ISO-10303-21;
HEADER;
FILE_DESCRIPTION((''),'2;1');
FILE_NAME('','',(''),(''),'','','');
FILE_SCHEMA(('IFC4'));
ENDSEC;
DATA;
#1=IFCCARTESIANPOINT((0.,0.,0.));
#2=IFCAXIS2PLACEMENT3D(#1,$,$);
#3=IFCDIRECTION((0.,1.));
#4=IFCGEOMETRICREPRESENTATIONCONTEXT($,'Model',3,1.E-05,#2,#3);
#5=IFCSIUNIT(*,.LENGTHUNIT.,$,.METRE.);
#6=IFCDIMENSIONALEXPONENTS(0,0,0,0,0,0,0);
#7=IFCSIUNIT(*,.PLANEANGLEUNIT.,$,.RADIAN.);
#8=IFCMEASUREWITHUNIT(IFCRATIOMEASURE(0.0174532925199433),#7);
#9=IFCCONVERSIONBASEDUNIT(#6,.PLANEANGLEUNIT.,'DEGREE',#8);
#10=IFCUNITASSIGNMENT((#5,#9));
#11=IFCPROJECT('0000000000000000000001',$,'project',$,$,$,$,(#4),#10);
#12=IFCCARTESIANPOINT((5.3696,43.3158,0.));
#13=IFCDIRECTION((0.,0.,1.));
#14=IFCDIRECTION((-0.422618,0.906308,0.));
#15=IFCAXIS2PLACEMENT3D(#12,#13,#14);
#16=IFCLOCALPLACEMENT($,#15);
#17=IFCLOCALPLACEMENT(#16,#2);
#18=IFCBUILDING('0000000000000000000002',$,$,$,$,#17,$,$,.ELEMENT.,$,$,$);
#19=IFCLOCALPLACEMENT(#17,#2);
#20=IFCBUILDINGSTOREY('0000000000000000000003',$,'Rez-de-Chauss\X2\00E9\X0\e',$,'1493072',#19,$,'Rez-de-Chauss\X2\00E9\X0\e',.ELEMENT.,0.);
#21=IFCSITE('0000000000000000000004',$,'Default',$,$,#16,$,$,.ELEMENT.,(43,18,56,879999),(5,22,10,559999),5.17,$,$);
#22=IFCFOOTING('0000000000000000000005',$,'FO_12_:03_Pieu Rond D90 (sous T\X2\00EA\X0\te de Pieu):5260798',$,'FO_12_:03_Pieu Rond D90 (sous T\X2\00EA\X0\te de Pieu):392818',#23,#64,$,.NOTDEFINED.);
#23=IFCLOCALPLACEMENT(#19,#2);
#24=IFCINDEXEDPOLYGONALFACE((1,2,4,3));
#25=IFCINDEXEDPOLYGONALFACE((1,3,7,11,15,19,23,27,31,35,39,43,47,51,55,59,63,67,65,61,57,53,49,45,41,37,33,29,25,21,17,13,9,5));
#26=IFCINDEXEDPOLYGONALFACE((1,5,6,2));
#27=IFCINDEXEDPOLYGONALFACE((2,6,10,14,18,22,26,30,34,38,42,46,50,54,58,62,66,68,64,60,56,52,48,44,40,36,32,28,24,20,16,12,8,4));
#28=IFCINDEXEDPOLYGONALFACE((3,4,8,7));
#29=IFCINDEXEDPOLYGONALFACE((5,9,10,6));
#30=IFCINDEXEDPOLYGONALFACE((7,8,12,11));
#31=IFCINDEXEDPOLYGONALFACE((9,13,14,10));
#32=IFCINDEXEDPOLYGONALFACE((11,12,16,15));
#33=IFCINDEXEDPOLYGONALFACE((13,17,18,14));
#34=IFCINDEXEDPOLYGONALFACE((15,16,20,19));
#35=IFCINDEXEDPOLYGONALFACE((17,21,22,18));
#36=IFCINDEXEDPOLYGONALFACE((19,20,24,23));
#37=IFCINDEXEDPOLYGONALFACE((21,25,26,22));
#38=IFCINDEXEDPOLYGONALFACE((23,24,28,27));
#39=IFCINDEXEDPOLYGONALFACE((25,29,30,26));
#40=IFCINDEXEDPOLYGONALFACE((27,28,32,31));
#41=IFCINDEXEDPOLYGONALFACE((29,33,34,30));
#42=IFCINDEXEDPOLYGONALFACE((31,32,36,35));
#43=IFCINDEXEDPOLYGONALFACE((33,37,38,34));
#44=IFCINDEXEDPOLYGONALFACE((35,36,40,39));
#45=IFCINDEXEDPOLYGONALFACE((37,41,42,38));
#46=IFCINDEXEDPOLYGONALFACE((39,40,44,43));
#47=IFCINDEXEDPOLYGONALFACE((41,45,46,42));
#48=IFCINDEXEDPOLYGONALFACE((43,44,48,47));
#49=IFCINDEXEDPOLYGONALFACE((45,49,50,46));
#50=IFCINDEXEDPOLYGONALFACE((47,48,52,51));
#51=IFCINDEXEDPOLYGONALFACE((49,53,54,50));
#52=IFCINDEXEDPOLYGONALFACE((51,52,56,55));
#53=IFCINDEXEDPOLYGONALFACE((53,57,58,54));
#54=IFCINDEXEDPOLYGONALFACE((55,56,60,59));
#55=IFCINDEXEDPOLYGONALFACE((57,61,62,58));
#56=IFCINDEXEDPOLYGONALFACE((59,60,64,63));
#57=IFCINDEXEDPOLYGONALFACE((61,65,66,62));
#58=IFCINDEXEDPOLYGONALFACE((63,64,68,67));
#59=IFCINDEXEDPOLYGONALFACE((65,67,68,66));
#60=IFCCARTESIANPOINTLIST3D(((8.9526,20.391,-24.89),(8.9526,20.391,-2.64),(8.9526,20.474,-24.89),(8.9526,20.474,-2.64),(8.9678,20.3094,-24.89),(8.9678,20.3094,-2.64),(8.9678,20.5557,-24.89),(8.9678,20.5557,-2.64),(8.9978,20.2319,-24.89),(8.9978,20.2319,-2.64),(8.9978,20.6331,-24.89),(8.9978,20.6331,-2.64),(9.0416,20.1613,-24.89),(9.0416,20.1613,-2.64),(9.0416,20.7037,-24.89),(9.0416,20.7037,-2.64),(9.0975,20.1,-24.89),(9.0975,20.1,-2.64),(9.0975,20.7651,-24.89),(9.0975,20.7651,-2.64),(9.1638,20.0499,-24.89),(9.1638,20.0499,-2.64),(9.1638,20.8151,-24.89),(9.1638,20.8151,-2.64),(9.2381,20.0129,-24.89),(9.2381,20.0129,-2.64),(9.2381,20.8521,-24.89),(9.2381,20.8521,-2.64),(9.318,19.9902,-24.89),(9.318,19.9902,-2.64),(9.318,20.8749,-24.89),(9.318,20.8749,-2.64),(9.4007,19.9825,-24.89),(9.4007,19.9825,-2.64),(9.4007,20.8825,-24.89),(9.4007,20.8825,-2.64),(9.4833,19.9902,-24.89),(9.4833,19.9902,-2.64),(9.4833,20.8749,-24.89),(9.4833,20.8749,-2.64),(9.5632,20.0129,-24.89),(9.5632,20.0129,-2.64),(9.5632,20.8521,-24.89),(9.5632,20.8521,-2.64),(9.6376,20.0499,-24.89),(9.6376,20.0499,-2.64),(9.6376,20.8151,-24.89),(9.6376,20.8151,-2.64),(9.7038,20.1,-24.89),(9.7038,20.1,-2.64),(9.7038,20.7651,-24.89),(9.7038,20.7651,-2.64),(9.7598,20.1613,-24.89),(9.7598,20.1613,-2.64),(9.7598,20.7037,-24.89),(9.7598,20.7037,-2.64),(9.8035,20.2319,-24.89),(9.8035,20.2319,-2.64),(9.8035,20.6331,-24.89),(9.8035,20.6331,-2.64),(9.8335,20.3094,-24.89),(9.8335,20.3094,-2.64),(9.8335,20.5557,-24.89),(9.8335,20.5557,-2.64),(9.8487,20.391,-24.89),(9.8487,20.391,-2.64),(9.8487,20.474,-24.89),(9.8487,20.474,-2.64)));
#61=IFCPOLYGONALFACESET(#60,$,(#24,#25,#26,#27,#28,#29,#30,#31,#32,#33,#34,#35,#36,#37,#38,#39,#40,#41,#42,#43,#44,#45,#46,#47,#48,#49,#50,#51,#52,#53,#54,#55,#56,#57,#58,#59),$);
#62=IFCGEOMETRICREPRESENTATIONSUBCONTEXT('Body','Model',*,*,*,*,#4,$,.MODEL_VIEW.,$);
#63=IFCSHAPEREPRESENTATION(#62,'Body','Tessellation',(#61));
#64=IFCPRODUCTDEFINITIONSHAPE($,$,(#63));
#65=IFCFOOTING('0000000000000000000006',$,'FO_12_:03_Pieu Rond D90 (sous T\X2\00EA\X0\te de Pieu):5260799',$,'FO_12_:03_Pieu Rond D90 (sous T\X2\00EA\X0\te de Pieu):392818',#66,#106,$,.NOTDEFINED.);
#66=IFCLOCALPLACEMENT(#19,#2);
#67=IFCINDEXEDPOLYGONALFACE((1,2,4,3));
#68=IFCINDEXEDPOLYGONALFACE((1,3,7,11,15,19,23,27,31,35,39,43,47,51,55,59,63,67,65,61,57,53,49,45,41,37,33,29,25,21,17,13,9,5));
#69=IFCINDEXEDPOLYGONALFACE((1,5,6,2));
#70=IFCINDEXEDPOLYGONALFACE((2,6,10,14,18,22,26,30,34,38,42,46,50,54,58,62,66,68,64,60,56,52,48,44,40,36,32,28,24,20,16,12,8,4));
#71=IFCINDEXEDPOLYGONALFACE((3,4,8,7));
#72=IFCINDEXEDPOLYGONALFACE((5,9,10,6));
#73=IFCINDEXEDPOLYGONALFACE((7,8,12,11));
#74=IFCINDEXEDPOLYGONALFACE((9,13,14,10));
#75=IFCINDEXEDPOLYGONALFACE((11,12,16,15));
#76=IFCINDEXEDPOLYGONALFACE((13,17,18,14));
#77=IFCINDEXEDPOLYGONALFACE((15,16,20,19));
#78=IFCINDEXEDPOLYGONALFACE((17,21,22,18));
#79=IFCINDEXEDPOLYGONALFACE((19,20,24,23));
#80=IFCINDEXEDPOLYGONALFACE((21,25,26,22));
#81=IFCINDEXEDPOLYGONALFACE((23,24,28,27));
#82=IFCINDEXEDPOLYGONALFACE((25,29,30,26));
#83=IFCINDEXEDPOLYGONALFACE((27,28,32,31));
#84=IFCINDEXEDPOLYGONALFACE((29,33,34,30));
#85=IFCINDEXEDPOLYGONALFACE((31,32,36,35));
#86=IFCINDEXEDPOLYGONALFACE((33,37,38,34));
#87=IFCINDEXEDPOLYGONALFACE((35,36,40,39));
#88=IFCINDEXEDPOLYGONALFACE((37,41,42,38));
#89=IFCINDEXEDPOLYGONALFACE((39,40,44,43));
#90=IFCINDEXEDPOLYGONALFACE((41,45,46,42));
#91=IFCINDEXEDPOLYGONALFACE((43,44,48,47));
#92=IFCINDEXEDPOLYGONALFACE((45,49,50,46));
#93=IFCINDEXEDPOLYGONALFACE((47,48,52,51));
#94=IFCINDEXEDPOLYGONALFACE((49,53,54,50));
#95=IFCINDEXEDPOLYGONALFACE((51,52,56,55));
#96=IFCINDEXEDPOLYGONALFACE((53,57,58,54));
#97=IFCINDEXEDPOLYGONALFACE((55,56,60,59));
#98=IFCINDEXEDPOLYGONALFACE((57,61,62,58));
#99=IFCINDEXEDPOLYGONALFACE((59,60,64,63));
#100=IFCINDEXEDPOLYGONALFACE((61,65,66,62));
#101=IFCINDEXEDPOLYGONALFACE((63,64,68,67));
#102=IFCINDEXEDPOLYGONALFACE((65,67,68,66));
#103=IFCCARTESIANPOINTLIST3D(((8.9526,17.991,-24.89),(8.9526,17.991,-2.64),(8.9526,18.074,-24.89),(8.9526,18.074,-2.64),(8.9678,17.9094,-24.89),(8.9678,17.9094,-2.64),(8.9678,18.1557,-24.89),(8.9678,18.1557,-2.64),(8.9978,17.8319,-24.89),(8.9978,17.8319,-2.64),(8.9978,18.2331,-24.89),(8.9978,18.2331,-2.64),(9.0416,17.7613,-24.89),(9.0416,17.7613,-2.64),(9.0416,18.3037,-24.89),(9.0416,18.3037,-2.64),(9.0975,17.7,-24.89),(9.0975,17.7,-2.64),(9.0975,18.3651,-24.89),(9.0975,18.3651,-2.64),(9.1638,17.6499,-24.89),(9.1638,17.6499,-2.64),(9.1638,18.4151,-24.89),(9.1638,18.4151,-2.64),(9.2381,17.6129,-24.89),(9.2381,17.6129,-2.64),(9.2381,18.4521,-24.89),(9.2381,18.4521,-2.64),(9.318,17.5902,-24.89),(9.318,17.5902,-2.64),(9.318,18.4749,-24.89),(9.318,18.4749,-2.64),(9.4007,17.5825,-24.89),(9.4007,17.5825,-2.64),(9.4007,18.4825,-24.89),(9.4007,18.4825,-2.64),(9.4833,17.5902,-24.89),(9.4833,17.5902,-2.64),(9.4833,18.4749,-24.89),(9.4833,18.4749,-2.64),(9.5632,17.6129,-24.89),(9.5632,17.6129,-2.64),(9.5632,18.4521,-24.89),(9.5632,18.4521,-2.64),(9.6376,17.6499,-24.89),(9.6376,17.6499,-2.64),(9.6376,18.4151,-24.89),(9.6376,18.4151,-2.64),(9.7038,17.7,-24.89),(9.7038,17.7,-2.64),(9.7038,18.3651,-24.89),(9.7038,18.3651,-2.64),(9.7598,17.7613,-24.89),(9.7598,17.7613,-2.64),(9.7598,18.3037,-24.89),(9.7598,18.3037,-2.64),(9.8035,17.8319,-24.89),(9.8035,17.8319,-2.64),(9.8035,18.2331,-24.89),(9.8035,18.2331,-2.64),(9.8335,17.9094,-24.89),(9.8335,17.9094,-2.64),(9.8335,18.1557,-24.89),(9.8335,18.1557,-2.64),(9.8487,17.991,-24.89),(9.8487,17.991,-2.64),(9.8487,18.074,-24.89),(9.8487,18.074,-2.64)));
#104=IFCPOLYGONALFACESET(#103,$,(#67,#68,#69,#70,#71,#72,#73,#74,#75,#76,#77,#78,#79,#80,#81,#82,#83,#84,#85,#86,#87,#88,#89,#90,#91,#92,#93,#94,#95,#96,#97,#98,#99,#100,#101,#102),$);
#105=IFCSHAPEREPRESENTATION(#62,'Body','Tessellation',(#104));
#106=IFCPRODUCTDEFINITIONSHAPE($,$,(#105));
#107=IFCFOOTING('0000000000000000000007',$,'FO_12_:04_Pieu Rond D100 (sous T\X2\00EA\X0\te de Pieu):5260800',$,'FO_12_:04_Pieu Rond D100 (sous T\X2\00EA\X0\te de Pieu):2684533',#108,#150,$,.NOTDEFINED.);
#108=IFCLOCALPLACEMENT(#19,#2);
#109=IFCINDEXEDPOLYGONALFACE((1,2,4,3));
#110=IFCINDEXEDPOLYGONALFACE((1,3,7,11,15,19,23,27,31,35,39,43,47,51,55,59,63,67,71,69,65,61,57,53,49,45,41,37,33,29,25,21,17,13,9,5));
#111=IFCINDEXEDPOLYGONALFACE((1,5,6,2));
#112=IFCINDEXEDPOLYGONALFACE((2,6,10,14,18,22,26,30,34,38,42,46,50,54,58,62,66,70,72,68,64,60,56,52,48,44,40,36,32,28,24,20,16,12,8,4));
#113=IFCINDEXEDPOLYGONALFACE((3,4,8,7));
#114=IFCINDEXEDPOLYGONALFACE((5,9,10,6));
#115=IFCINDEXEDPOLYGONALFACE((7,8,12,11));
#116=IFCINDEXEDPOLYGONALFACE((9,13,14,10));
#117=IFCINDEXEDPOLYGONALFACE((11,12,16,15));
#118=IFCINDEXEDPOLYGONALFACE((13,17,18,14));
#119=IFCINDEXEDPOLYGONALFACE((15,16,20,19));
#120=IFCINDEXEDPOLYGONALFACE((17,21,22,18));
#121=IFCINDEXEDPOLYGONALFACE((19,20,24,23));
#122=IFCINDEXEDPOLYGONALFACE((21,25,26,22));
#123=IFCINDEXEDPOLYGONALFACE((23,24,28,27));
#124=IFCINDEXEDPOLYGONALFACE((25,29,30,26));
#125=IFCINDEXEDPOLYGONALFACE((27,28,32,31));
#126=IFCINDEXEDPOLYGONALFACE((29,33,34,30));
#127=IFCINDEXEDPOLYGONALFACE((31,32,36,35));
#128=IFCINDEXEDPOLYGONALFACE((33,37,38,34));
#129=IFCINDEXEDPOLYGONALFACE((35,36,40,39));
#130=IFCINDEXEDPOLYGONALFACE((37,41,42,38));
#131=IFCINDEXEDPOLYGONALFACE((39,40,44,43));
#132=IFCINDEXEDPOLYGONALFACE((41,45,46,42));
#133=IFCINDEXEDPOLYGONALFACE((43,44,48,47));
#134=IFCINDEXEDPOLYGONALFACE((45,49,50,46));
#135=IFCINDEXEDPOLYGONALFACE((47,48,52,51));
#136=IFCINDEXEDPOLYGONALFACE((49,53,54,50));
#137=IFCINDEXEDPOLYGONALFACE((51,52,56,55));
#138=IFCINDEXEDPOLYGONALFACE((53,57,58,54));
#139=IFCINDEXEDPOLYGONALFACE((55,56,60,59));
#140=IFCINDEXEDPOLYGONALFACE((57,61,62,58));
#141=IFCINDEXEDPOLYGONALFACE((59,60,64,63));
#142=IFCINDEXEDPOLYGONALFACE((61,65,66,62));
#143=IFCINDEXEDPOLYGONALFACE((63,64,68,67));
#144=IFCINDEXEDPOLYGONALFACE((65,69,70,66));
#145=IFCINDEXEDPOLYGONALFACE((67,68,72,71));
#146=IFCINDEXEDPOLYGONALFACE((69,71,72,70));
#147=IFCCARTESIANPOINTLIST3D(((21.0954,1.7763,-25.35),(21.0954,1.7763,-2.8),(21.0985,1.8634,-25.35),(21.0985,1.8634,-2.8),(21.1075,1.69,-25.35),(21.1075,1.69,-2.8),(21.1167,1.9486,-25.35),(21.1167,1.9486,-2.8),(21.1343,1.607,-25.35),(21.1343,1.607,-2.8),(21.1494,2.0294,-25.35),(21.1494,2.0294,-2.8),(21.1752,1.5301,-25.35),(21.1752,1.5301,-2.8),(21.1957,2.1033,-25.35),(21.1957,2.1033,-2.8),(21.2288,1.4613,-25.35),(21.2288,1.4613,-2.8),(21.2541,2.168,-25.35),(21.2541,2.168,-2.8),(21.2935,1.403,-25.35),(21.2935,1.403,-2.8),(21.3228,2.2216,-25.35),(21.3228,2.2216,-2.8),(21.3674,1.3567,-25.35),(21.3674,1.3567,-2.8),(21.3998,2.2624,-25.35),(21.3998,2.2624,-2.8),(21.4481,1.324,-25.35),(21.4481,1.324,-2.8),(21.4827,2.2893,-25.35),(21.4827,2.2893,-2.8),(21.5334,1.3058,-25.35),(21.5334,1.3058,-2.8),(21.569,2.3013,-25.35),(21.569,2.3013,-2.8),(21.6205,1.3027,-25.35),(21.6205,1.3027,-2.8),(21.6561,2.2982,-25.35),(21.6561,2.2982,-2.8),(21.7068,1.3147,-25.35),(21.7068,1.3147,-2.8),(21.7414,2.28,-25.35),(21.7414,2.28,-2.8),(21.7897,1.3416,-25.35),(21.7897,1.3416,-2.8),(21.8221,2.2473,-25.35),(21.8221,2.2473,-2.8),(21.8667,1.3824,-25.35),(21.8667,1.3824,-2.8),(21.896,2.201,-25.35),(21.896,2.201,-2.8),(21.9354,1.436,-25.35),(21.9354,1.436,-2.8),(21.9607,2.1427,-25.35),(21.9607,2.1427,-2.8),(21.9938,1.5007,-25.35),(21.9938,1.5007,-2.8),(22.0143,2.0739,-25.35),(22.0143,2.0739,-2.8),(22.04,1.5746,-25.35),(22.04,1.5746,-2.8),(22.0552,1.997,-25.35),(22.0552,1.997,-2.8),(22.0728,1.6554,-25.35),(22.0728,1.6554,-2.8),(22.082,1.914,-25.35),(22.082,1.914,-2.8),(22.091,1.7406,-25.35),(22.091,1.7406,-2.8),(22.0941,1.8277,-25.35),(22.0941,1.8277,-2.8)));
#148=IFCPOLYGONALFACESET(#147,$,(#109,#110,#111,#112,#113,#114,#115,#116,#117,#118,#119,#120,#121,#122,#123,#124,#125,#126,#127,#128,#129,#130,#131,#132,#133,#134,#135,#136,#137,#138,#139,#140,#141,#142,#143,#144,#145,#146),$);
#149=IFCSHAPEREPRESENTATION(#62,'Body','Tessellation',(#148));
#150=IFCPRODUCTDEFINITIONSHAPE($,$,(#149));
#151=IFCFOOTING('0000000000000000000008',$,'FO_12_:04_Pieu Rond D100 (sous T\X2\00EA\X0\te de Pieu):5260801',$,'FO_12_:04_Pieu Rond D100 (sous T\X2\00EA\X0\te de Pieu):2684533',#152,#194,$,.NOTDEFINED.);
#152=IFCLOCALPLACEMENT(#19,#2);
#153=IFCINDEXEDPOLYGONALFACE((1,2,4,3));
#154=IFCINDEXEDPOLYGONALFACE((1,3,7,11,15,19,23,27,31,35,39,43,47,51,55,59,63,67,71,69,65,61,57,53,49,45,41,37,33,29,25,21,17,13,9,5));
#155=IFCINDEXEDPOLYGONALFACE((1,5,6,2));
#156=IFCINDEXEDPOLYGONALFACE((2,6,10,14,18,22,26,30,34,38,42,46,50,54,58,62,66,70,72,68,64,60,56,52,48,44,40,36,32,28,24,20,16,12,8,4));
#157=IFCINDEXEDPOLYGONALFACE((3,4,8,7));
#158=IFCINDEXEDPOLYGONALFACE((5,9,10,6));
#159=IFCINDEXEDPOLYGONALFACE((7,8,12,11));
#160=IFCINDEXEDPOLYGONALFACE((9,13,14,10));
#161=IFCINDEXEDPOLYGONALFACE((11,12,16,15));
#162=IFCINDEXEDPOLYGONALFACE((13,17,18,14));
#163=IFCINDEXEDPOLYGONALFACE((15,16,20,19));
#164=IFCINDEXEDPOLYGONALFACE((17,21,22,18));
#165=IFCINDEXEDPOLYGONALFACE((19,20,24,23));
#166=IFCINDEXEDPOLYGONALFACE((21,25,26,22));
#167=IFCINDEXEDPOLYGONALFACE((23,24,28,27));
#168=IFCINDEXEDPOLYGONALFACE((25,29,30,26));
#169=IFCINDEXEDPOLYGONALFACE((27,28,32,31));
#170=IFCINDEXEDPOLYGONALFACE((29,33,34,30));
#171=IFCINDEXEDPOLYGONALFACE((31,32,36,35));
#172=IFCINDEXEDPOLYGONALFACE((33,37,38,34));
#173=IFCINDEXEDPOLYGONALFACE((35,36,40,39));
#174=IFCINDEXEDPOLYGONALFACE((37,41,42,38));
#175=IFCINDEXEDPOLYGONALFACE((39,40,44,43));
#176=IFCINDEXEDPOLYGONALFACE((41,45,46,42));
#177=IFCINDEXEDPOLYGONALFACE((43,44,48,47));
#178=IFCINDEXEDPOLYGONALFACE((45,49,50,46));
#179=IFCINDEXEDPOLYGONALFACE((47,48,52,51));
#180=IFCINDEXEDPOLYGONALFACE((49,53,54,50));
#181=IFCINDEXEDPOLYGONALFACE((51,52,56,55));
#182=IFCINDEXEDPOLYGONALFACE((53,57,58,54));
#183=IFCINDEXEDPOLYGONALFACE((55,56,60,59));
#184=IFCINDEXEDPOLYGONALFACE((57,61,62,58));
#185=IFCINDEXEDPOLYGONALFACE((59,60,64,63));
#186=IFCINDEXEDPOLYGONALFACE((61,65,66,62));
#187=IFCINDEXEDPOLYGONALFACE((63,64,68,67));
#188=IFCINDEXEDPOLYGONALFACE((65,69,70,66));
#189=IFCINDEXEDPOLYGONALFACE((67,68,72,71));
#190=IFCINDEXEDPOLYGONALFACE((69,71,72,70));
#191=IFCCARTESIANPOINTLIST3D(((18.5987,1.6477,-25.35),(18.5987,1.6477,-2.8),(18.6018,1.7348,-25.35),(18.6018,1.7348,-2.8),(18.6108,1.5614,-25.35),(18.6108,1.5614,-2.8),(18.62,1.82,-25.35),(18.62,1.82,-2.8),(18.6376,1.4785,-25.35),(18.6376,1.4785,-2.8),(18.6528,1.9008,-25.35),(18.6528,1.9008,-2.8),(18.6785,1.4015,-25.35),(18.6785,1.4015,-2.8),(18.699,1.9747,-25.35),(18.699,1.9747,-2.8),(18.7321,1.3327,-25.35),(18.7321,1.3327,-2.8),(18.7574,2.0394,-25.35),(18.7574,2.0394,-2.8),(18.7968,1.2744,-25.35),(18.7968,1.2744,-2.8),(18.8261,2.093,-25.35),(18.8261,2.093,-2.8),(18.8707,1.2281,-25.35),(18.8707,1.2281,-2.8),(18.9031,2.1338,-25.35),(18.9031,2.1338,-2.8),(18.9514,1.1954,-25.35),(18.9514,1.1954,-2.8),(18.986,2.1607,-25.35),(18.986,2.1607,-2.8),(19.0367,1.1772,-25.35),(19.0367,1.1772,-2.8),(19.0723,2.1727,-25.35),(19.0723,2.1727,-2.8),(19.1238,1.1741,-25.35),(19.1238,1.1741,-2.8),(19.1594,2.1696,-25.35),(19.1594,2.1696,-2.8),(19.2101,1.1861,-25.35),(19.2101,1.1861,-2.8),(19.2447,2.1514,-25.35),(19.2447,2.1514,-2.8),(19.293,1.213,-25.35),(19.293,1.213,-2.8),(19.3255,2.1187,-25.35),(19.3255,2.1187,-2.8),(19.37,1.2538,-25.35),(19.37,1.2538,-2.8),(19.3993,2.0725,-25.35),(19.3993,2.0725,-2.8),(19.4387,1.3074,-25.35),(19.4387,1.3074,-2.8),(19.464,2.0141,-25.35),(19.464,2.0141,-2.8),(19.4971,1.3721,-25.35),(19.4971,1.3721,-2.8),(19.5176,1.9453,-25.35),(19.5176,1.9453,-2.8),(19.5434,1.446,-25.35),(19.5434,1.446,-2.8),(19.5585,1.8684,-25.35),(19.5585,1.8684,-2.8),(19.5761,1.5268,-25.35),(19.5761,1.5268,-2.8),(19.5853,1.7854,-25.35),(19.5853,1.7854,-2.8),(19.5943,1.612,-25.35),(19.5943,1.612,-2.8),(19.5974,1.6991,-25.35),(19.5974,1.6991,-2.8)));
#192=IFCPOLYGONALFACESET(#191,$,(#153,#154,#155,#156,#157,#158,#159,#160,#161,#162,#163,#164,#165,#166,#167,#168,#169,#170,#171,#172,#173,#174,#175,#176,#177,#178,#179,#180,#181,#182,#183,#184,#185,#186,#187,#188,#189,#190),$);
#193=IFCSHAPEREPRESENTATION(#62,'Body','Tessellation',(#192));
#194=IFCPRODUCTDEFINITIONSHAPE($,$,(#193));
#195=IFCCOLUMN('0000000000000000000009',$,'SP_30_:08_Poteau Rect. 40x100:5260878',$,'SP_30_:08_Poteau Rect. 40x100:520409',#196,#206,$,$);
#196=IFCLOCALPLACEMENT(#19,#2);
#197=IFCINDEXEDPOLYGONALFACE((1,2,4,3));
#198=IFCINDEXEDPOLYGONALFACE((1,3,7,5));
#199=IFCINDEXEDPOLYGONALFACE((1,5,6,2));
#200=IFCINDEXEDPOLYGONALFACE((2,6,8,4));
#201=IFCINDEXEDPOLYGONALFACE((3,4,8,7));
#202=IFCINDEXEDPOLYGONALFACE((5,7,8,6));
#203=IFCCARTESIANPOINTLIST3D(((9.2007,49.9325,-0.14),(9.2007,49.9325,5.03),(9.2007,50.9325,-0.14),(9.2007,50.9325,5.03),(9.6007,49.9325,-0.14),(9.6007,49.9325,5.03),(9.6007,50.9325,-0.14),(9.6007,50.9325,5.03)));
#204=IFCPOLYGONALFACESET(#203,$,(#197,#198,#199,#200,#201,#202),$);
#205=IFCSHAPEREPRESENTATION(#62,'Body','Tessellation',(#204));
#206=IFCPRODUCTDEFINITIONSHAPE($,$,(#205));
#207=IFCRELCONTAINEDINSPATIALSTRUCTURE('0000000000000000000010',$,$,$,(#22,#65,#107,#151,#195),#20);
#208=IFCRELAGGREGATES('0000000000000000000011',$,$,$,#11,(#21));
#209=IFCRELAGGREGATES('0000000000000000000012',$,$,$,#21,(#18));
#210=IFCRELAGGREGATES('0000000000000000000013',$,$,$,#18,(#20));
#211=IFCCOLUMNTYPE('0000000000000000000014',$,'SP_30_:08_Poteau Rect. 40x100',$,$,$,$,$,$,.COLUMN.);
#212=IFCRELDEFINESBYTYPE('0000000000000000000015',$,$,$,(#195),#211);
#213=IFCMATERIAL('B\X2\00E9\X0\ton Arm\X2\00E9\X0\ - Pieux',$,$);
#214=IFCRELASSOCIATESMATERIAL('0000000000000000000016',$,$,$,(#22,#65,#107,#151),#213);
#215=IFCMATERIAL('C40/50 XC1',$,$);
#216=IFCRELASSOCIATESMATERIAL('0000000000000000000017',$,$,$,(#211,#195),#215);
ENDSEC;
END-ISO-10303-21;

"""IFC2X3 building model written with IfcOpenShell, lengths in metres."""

from ifc_helpers import new_model, entity, si_unit, converted_unit, direction, frame, frame_2d, origin, place, context, subcontext, project, spatial, rectangle, circle, extrude, source, transform, mapped, material, type_object, type_shapes, element, save


model = new_model("IFC2X3")

# Units and contexts
model_context = context("Model", 3, precision=1e-05, world=origin(), true_north=direction((0.0, 1.0)))
body_context = subcontext(model_context, "Body", "Model", "MODEL_VIEW")
ifc_project = project(units=[si_unit("LENGTHUNIT", "METRE"), converted_unit("PLANEANGLEUNIT", "DEGREE", entity("IfcRatioMeasure", 0.0174532925199433), si_unit("PLANEANGLEUNIT", "RADIAN"), dimensions=[0, 0, 0, 0, 0, 0, 0])], contexts=[model_context])

# Site, building, storey
site_placement = place(None, frame((5.3696, 43.3158, 0.0), z_axis=(0.0, 0.0, 1.0), x_axis=(-0.422618, 0.906308, 0.0)))
site = spatial("IfcSite", under=ifc_project, at=site_placement, Name="Default", CompositionType="ELEMENT", RefLatitude=(43, 18, 56, 879999), RefLongitude=(5, 22, 10, 559999), RefElevation=5.17)
building_placement = place(site_placement, origin())
building = spatial("IfcBuilding", under=site, at=building_placement, CompositionType="ELEMENT")
storey_placement = place(building_placement, origin())
storey = spatial("IfcBuildingStorey", under=building, at=storey_placement, Name="Rez-de-Chaussée", ObjectType="1493072", LongName="Rez-de-Chaussée", CompositionType="ELEMENT", Elevation=0.0)

# Footings
ifc_material_1 = material(Name="Béton Armé - Pieux")
footing_1_placement = place(storey_placement, origin())
element("IfcFooting", 1, at=footing_1_placement, inside=storey, material=ifc_material_1, Name="FO_12_:03_Pieu Rond D90 (sous Tête de Pieu):5260798", ObjectType="FO_12_:03_Pieu Rond D90 (sous Tête de Pieu):392818", PredefinedType="NOTDEFINED", context=body_context, shape_type="SweptSolid", body=[
    extrude(circle(Radius=0.45, at=frame_2d((0.0, 0.0), x_axis=(1.0, 0.0))), frame((9.4007, 20.4325, -24.89), z_axis=(0.0, 0.0, 1.0), x_axis=(0.0, -1.0, 0.0)), (0.0, 0.0, 1.0), 22.25),
])
footing_2_placement = place(storey_placement, origin())
element("IfcFooting", 2, at=footing_2_placement, inside=storey, material=ifc_material_1, Name="FO_12_:03_Pieu Rond D90 (sous Tête de Pieu):5260799", ObjectType="FO_12_:03_Pieu Rond D90 (sous Tête de Pieu):392818", PredefinedType="NOTDEFINED", context=body_context, shape_type="SweptSolid", body=[
    extrude(circle(Radius=0.45, at=frame_2d((0.0, 0.0), x_axis=(1.0, 0.0))), frame((9.4007, 18.0325, -24.89), z_axis=(0.0, 0.0, 1.0), x_axis=(0.0, -1.0, 0.0)), (0.0, 0.0, 1.0), 22.25),
])
footing_3_placement = place(storey_placement, origin())
element("IfcFooting", 3, at=footing_3_placement, inside=storey, material=ifc_material_1, Name="FO_12_:04_Pieu Rond D100 (sous Tête de Pieu):5260800", ObjectType="FO_12_:04_Pieu Rond D100 (sous Tête de Pieu):2684533", PredefinedType="NOTDEFINED", context=body_context, shape_type="SweptSolid", body=[
    extrude(circle(Radius=0.5, at=frame_2d((0.0, 0.0), x_axis=(1.0, 0.0))), frame((21.5947, 1.802, -25.35), z_axis=(0.0, 0.0, 1.0), x_axis=(-0.998676, -0.051439, 0.0)), (0.0, 0.0, 1.0), 22.55),
])
footing_4_placement = place(storey_placement, origin())
element("IfcFooting", 4, at=footing_4_placement, inside=storey, material=ifc_material_1, Name="FO_12_:04_Pieu Rond D100 (sous Tête de Pieu):5260801", ObjectType="FO_12_:04_Pieu Rond D100 (sous Tête de Pieu):2684533", PredefinedType="NOTDEFINED", context=body_context, shape_type="SweptSolid", body=[
    extrude(circle(Radius=0.5, at=frame_2d((0.0, 0.0), x_axis=(1.0, 0.0))), frame((19.0981, 1.6734, -25.35), z_axis=(0.0, 0.0, 1.0), x_axis=(-0.998676, -0.051439, 0.0)), (0.0, 0.0, 1.0), 22.55),
])

# Column
ifc_material_2 = material(Name="C40/50 XC1")
column_type_1 = type_object("IfcColumnType", Name="SP_30_:08_Poteau Rect. 40x100", PredefinedType="COLUMN", material=ifc_material_2)
shared_shape_1 = source(origin(), body_context, "Body", "SweptSolid", [
    extrude(rectangle(XDim=1.0, YDim=0.4, at=frame_2d((0.0, 0.0), x_axis=(1.0, 0.0))), frame((9.4007, 50.4325, -0.14), z_axis=(0.0, 0.0, 1.0), x_axis=(0.0, 1.0, 0.0)), (0.0, 0.0, 1.0), 5.17),
])
type_shapes(column_type_1, [shared_shape_1])
column_1_placement = place(storey_placement, origin())
element("IfcColumn", 5, at=column_1_placement, inside=storey, type_object=column_type_1, material=ifc_material_2, Name="SP_30_:08_Poteau Rect. 40x100:5260878", ObjectType="SP_30_:08_Poteau Rect. 40x100:520409", context=body_context, shape_type="MappedRepresentation", body=[
    mapped(shared_shape_1, transform((0.0, 0.0, 0.0), scale=1.0)),
])

save(model, "model.ifc")
